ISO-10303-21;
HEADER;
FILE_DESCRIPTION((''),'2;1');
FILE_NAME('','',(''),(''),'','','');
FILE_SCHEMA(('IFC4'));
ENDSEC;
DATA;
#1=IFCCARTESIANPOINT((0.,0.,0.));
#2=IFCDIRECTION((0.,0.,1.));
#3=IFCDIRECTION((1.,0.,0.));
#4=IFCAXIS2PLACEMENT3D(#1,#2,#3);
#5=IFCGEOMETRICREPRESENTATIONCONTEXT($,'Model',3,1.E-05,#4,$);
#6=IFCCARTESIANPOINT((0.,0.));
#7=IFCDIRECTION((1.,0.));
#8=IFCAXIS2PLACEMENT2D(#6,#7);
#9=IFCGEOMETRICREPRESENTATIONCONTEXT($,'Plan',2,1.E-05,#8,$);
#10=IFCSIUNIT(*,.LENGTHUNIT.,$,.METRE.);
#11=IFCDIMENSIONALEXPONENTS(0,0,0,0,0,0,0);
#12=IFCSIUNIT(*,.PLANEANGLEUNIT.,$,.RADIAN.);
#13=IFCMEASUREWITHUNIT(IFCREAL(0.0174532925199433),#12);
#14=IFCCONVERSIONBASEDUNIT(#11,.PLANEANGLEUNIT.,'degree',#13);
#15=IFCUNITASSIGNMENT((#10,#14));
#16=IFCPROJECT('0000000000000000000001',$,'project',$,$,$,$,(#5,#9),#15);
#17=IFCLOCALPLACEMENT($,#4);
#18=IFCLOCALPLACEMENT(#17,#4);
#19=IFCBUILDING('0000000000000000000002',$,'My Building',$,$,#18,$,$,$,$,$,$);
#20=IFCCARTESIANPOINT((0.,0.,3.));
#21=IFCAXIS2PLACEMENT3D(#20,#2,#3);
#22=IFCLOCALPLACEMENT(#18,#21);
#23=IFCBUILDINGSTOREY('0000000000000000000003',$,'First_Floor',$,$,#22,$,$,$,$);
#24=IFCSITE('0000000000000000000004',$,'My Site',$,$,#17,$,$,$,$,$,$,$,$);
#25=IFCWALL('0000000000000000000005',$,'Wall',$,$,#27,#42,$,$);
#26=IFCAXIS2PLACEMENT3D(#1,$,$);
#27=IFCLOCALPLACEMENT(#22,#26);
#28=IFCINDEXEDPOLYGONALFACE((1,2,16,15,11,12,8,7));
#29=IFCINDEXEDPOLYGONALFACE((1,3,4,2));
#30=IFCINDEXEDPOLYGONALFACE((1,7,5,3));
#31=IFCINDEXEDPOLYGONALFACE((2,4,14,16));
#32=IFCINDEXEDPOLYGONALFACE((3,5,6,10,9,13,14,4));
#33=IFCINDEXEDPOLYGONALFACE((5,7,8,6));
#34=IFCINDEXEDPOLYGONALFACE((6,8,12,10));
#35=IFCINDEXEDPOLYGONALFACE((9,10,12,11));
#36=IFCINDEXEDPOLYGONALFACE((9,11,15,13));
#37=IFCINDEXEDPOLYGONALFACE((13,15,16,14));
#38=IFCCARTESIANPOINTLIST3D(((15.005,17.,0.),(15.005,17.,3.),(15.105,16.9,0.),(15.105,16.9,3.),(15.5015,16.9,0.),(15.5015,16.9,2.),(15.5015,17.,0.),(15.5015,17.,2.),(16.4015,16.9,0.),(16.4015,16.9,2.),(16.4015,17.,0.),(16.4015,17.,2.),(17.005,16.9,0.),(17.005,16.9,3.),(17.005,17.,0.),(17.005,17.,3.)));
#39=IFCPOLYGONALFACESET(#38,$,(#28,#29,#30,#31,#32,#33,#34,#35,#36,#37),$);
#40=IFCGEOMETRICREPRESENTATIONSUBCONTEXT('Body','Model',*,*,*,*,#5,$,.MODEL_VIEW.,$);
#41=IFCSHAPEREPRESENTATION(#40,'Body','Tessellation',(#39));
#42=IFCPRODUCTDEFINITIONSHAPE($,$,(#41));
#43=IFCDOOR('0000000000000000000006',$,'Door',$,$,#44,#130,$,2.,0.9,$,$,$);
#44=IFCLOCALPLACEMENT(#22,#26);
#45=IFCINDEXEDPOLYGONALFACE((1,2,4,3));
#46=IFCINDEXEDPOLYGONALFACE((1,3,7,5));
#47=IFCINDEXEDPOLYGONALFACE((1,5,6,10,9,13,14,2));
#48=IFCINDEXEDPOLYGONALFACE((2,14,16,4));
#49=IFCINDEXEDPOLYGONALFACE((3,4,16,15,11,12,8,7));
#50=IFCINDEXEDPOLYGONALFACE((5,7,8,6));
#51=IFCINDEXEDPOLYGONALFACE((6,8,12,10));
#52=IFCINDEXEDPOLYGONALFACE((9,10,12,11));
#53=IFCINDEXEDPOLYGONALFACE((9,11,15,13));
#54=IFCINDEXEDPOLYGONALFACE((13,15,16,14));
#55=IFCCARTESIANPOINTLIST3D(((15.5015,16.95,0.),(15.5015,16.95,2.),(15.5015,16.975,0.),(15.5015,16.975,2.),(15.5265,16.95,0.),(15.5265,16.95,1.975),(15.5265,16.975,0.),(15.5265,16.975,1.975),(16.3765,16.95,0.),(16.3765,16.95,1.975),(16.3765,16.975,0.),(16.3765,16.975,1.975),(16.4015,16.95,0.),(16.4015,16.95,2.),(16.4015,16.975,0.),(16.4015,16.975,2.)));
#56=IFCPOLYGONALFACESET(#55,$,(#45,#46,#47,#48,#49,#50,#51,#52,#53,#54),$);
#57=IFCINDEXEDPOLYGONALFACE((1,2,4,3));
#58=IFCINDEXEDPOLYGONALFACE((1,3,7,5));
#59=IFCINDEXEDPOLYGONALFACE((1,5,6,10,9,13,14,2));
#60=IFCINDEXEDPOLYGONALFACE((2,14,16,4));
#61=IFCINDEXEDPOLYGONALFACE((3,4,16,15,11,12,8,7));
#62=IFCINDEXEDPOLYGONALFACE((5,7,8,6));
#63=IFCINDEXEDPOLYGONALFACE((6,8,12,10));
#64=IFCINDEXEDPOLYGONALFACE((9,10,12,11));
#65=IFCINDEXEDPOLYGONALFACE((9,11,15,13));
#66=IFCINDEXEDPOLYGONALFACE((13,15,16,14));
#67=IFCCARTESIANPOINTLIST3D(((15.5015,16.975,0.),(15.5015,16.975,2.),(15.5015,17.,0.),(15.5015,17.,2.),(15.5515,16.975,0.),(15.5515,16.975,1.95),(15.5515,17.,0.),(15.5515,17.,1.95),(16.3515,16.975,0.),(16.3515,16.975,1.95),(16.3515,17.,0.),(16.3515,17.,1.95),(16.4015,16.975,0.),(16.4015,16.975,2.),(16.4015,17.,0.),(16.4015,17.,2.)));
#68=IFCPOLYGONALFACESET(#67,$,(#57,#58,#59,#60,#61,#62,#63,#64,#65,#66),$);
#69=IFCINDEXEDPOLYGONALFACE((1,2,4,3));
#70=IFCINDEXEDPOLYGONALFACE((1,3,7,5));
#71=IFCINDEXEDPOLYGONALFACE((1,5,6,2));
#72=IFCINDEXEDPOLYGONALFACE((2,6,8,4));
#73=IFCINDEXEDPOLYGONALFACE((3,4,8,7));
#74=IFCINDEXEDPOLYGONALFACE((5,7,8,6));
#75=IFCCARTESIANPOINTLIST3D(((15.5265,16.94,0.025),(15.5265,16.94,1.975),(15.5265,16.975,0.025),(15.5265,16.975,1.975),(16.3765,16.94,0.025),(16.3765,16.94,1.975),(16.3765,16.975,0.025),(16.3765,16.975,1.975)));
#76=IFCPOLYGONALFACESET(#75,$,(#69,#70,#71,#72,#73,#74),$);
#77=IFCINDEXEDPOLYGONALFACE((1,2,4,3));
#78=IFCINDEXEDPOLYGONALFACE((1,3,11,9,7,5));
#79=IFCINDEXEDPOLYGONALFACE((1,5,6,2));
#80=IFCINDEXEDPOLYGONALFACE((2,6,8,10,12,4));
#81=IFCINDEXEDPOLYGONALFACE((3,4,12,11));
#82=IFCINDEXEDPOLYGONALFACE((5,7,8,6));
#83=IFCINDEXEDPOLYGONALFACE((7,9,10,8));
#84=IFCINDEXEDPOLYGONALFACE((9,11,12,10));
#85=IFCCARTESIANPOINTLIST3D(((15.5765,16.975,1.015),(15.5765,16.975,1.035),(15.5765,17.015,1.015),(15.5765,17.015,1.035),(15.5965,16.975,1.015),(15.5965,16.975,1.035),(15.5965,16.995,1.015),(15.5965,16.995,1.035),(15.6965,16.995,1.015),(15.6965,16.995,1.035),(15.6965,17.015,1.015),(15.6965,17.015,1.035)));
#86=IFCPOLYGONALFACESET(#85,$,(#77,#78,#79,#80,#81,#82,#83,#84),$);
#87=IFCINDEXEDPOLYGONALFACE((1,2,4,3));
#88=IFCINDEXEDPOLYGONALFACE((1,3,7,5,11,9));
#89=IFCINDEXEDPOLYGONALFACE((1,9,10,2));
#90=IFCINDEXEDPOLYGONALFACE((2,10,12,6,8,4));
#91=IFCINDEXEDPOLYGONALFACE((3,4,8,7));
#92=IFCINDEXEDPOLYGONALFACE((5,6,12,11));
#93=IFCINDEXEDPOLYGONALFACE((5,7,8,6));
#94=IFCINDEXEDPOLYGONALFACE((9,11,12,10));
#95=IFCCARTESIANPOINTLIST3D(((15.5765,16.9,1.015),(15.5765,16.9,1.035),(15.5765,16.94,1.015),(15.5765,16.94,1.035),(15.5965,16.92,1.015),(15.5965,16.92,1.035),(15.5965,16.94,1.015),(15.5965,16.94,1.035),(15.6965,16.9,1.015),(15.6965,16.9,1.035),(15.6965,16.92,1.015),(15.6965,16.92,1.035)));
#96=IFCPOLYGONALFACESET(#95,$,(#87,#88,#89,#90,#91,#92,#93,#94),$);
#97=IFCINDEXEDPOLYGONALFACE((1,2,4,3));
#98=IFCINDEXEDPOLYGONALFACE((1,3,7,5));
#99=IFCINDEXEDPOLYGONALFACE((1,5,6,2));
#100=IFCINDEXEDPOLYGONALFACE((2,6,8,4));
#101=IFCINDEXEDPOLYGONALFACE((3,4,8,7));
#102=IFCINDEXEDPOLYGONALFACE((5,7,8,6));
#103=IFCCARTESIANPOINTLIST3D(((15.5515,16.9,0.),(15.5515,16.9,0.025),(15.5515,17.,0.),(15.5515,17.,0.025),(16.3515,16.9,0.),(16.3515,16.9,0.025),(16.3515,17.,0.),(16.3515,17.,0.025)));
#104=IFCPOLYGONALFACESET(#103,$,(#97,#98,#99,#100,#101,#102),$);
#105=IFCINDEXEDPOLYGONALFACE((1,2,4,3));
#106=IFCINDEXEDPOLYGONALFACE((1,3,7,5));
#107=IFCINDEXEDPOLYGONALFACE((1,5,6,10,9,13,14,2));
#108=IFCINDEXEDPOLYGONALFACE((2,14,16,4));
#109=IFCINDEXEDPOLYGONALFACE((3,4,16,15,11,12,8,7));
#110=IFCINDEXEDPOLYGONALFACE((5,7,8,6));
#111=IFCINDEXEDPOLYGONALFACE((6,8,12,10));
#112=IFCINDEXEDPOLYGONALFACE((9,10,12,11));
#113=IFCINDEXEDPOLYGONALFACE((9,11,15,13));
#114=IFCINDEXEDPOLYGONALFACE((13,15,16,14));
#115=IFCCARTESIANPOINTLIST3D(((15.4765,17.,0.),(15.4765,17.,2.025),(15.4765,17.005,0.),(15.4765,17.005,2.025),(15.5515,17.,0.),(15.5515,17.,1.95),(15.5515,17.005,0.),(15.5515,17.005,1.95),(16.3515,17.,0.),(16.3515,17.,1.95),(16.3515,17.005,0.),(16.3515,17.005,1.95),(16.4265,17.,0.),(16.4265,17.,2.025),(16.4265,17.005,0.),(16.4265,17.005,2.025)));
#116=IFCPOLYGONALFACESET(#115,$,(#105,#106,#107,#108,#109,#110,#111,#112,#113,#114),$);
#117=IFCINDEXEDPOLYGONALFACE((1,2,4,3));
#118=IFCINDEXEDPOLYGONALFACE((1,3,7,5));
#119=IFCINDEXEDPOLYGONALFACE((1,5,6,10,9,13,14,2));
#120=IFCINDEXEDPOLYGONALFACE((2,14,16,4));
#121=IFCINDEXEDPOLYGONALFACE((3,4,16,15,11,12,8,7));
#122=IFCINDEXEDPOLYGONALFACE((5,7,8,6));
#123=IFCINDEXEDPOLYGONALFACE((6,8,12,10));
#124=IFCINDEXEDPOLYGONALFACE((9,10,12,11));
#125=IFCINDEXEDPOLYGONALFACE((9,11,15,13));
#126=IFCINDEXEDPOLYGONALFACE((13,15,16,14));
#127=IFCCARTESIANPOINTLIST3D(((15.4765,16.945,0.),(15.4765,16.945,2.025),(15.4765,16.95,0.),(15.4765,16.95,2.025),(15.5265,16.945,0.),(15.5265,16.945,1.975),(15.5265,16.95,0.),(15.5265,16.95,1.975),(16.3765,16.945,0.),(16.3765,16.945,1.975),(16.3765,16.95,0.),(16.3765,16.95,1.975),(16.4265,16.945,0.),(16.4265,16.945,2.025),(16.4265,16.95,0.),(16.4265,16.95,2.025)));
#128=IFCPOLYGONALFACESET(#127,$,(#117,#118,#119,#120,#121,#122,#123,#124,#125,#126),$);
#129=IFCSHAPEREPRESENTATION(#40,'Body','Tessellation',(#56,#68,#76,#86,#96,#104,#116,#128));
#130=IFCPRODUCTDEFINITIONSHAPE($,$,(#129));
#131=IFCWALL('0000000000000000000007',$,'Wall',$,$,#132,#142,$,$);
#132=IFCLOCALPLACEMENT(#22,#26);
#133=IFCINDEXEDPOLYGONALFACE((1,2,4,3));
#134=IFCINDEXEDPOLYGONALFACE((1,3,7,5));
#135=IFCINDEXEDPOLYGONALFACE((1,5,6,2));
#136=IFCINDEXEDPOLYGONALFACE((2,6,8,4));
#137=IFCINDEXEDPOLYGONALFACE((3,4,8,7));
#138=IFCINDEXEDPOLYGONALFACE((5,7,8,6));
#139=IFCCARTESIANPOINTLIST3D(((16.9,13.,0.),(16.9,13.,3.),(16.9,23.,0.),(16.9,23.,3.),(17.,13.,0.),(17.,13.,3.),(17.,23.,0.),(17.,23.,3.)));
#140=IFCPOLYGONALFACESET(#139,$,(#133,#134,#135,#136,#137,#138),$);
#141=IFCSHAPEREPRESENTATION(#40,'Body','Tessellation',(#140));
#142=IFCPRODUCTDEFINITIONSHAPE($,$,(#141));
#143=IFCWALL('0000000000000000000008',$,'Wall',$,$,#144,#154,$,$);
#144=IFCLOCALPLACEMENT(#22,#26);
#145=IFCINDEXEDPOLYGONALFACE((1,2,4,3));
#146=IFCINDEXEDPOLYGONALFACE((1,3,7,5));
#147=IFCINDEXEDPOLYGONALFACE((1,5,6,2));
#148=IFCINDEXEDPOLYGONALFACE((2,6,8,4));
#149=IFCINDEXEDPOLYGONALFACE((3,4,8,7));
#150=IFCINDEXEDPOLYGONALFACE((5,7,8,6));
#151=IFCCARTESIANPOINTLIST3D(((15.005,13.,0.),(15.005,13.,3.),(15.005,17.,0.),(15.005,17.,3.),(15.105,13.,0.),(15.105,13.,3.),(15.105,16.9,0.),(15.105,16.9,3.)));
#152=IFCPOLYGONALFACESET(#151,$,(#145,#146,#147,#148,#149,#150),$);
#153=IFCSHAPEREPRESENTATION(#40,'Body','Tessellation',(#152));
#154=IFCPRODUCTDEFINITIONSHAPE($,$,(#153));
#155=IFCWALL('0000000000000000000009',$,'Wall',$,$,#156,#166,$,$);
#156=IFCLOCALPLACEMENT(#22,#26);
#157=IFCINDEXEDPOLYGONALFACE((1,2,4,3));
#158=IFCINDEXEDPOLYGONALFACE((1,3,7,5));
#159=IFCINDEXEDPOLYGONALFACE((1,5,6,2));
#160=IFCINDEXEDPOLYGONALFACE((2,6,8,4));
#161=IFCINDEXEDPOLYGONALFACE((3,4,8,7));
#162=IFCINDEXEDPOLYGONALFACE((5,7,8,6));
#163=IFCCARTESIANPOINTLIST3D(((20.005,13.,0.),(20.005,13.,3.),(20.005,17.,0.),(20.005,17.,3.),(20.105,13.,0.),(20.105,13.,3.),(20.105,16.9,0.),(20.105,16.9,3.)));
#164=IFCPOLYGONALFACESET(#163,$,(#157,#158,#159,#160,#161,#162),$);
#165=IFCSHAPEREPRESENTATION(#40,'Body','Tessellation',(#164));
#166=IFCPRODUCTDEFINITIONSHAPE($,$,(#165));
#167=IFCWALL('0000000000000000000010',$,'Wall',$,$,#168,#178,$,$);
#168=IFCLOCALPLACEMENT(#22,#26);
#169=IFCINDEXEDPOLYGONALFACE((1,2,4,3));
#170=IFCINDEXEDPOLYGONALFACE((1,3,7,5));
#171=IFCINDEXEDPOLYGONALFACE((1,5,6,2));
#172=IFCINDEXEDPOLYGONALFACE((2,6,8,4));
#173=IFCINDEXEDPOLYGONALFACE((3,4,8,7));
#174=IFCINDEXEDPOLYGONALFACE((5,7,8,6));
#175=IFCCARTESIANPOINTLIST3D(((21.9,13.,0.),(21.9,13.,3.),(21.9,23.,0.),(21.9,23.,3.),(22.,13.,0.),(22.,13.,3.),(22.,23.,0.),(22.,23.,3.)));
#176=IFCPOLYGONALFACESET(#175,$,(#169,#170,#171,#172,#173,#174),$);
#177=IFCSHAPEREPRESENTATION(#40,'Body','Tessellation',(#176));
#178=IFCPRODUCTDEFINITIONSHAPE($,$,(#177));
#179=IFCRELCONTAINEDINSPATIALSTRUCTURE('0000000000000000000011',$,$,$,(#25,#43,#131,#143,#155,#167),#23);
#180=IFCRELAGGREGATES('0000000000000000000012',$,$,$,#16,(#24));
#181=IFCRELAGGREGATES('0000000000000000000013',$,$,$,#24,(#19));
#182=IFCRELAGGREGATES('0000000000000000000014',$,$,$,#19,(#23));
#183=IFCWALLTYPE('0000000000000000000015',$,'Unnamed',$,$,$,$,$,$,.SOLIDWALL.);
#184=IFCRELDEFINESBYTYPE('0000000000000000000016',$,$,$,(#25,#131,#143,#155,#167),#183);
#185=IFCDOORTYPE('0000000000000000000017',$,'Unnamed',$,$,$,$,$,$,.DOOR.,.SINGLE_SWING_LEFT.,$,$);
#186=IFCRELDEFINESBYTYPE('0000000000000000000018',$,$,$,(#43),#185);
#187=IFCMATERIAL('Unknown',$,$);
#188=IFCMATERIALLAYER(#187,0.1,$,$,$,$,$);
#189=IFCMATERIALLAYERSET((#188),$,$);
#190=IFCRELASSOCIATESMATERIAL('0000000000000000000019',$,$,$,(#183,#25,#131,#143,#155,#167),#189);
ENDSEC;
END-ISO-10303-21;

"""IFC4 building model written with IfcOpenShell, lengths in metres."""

from ifc_helpers import new_model, entity, si_unit, converted_unit, frame, origin_with_axes, origin_2d_with_axis, place, context, subcontext, project, spatial, line, indexed_curve, outline, extrude, shape, source, transform, mapped, material, layer, layer_set, layer_usage, type_object, type_shapes, element, fill, save


model = new_model("IFC4")

# Units and contexts
model_context = context("Model", 3, precision=1e-05, world=origin_with_axes())
plan_context = context("Plan", 2, precision=1e-05, world=origin_2d_with_axis())
body_context_1 = subcontext(model_context, "Body", "Model", "MODEL_VIEW")
body_context_2 = subcontext(plan_context, "Body", "Plan", "PLAN_VIEW")
ifc_project = project(units=[si_unit("LENGTHUNIT", "METRE"), converted_unit("PLANEANGLEUNIT", "degree", entity("IfcReal", 0.0174532925199433), si_unit("PLANEANGLEUNIT", "RADIAN"), dimensions=[0, 0, 0, 0, 0, 0, 0])], contexts=[model_context, plan_context])

# Site, building, storey
site_placement = place(None, origin_with_axes())
site = spatial("IfcSite", under=ifc_project, at=site_placement, Name="My Site")
building_placement = place(site_placement, origin_with_axes())
building = spatial("IfcBuilding", under=site, at=building_placement, Name="My Building")
storey_placement = place(building_placement, frame((0.0, 0.0, 3.0), z_axis=(0.0, 0.0, 1.0), x_axis=(1.0, 0.0, 0.0)))
storey = spatial("IfcBuildingStorey", under=building, at=storey_placement, Name="First_Floor")

# Shared definitions
ifc_material = material(Name="Unknown")
ifc_layer = layer(ifc_material, 0.1)
ifc_layer_set = layer_set([ifc_layer])
wall_type = type_object("IfcWallType", Name="Unnamed", PredefinedType="SOLIDWALL", material=ifc_layer_set)
shared_shape_1 = source(origin_with_axes(), body_context_1, "Body", "SweptSolid", [
    extrude(outline(indexed_curve([(0.0, 0.0), (0.9, 0.0), (0.9, 2.0), (0.0, 2.0)], segments=[line(1, 2, 3, 4, 1)])), frame((0.0, -0.6, 0.0), z_axis=(0.0, -1.0, 0.0), x_axis=(1.0, 0.0, 0.0)), (0.0, 0.0, -1.0), 1.2),
])
door_type = type_object("IfcDoorType", Name="Unnamed", OperationType="SINGLE_SWING_LEFT", PredefinedType="DOOR")
shared_shape_2 = source(origin_with_axes(), body_context_1, "Body", "SweptSolid", [
    extrude(outline(indexed_curve([(0.0, 0.0), (0.0, 2.0), (0.9, 2.0), (0.9, 0.0), (0.875, 0.0), (0.875, 1.975), (0.025, 1.975), (0.025, 0.0)], segments=[line(1, 2, 3, 4, 5, 6, 7, 8, 1)])), frame((0.0, 0.025, 0.0), z_axis=(0.0, -1.0, 0.0), x_axis=(1.0, 0.0, 0.0)), (0.0, 0.0, -1.0), 0.025),
    extrude(outline(indexed_curve([(0.0, 0.0), (0.0, 2.0), (0.9, 2.0), (0.9, 0.0), (0.85, 0.0), (0.85, 1.95), (0.05, 1.95), (0.05, 0.0)], segments=[line(1, 2, 3, 4, 5, 6, 7, 8, 1)])), frame((0.0, 0.0, 0.0), z_axis=(0.0, -1.0, 0.0), x_axis=(1.0, 0.0, 0.0)), (0.0, 0.0, -1.0), 0.025),
    extrude(outline(indexed_curve([(0.0, 0.0), (0.85, 0.0), (0.85, 0.035), (0.0, 0.035)], segments=[line(1, 2, 3, 4, 1)])), frame((0.025, 0.025, 0.025), z_axis=(0.0, 0.0, 1.0), x_axis=(1.0, 0.0, 0.0)), (0.0, 0.0, 1.0), 1.95),
    extrude(outline(indexed_curve([(0.0, 0.0), (0.0, -0.04), (-0.12, -0.04), (-0.12, -0.02), (-0.02, -0.02), (-0.02, 0.0)], segments=[line(1, 2, 3, 4, 5, 6, 1)])), frame((0.825, 0.025, 1.015), z_axis=(0.0, 0.0, 1.0), x_axis=(1.0, 0.0, 0.0)), (0.0, 0.0, 1.0), 0.02),
    extrude(outline(indexed_curve([(0.0, 0.0), (0.0, 0.04), (-0.12, 0.04), (-0.12, 0.02), (-0.02, 0.02), (-0.02, 0.0)], segments=[line(1, 2, 3, 4, 5, 6, 1)])), frame((0.825, 0.06, 1.015), z_axis=(0.0, 0.0, 1.0), x_axis=(1.0, 0.0, 0.0)), (0.0, 0.0, 1.0), 0.02),
    extrude(outline(indexed_curve([(0.0, 0.0), (0.8, 0.0), (0.8, 0.1), (0.0, 0.1)], segments=[line(1, 2, 3, 4, 1)])), frame((0.05, 0.0, 0.0), z_axis=(0.0, 0.0, 1.0), x_axis=(1.0, 0.0, 0.0)), (0.0, 0.0, 1.0), 0.025),
    extrude(outline(indexed_curve([(0.0, 0.0), (0.0, 2.025), (0.95, 2.025), (0.95, 0.0), (0.875, 0.0), (0.875, 1.95), (0.075, 1.95), (0.075, 0.0)], segments=[line(1, 2, 3, 4, 5, 6, 7, 8, 1)])), frame((-0.025, -0.005, 0.0), z_axis=(0.0, -1.0, 0.0), x_axis=(1.0, 0.0, 0.0)), (0.0, 0.0, -1.0), 0.005),
    extrude(outline(indexed_curve([(0.0, 0.0), (0.0, 2.025), (0.95, 2.025), (0.95, 0.0), (0.9, 0.0), (0.9, 1.975), (0.05, 1.975), (0.05, 0.0)], segments=[line(1, 2, 3, 4, 5, 6, 7, 8, 1)])), frame((-0.025, 0.05, 0.0), z_axis=(0.0, -1.0, 0.0), x_axis=(1.0, 0.0, 0.0)), (0.0, 0.0, -1.0), 0.005),
])
shared_shape_3 = source(origin_with_axes(), body_context_2, "Body", "Curve2D", [
    entity("IfcIndexedPolyCurve", entity("IfcCartesianPointList2D", [[0.0, 0.0], [0.0, 0.05], [0.025, 0.05], [0.025, 0.025], [0.05, 0.025], [0.05, 0.0]]), [entity("IfcLineIndex", [1, 2, 3, 4, 5, 6, 1])]),
    entity("IfcIndexedPolyCurve", entity("IfcCartesianPointList2D", [[0.9, 0.0], [0.9, 0.05], [0.875, 0.05], [0.875, 0.025], [0.85, 0.025], [0.85, 0.0]]), [entity("IfcLineIndex", [1, 2, 3, 4, 5, 6, 1])]),
    entity("IfcTrimmedCurve", entity("IfcEllipse", entity("IfcAxis2Placement2D", entity("IfcCartesianPoint", [0.06, 0.05]), entity("IfcDirection", [1.0, 0.0])), 0.815, 0.85), [entity("IfcCartesianPoint", [0.875, 0.05])], [entity("IfcCartesianPoint", [0.06, 0.9])], True, "CARTESIAN"),
    entity("IfcIndexedPolyCurve", entity("IfcCartesianPointList2D", [[0.025, 0.05], [0.06, 0.05], [0.06, 0.9], [0.025, 0.9]]), [entity("IfcLineIndex", [1, 2, 3, 4, 1])]),
])
type_shapes(door_type, [shared_shape_2, shared_shape_3])

# Wall, opening, door
ifc_layer_usage_1 = layer_usage(ifc_layer_set, "AXIS2", "POSITIVE", 0.0)
wall_1_placement = place(storey_placement, frame((17.005, 17.0, 0.0), z_axis=(0.0, 0.0, 1.0), x_axis=(-1.0, 0.0, 0.0)))
wall_1 = element("IfcWall", 1, at=wall_1_placement, inside=storey, type_object=wall_type, material=ifc_layer_usage_1, Name="Wall", context=body_context_1, shape_type="SweptSolid", body=[
    extrude(outline(indexed_curve([(0.0, 0.0), (0.0, 0.1), (1.9, 0.1), (2.0, 0.0)], segments=[line(1, 2, 3, 4, 1)])), origin_with_axes(), (0.0, 0.0, 1.0), 3.0),
])
opening_1_placement = place(wall_1_placement, frame((0.6035, 0.0, 0.0), z_axis=(0.0, 0.0, 1.0), x_axis=(1.0, 0.0, 0.0)))
opening_1 = element("IfcOpeningElement", 2, at=opening_1_placement, cuts=wall_1, PredefinedType="OPENING", context=body_context_1, shape_type="MappedRepresentation", body=[
    mapped(shared_shape_1, transform((0.0, 0.0, 0.0), x_axis=(1.0, 0.0, 0.0), y_axis=(0.0, 1.0, 0.0), z_axis=(0.0, 0.0, 1.0), scale=1.0)),
])
door_1_placement = place(opening_1_placement, frame((0.0, 0.0, 0.0), z_axis=(0.0, 0.0, 1.0), x_axis=(1.0, 0.0, 0.0)))
door_1 = element("IfcDoor", 3, at=door_1_placement, inside=storey, type_object=door_type, Name="Door", OverallHeight=2.0, OverallWidth=0.9, shapes=[
    shape(body_context_1, "Body", "MappedRepresentation", [mapped(shared_shape_2, transform((0.0, 0.0, 0.0), x_axis=(1.0, 0.0, 0.0), y_axis=(0.0, 1.0, 0.0), z_axis=(0.0, 0.0, 1.0), scale=1.0))]),
    shape(body_context_2, "Body", "MappedRepresentation", [mapped(shared_shape_3, transform((0.0, 0.0, 0.0), x_axis=(1.0, 0.0, 0.0), y_axis=(0.0, 1.0, 0.0), z_axis=(0.0, 0.0, 1.0), scale=1.0))]),
])
fill(opening_1, door_1)

# Walls
ifc_layer_usage_2 = layer_usage(ifc_layer_set, "AXIS2", "POSITIVE", 0.0)
wall_2_placement = place(storey_placement, frame((16.9, 23.0, 0.0), z_axis=(0.0, 0.0, 1.0), x_axis=(0.0, -1.0, 0.0)))
element("IfcWall", 4, at=wall_2_placement, inside=storey, type_object=wall_type, material=ifc_layer_usage_2, Name="Wall", context=body_context_1, shape_type="SweptSolid", body=[
    extrude(outline(indexed_curve([(0.0, 0.0), (0.0, 0.1), (10.0, 0.1), (10.0, 0.0)], segments=[line(1, 2, 3, 4, 1)])), origin_with_axes(), (0.0, 0.0, 1.0), 3.0),
])
ifc_layer_usage_3 = layer_usage(ifc_layer_set, "AXIS2", "POSITIVE", 0.0)
wall_3_placement = place(storey_placement, frame((15.005, 17.0, 0.0), z_axis=(0.0, 0.0, 1.0), x_axis=(0.0, -1.0, 0.0)))
element("IfcWall", 5, at=wall_3_placement, inside=storey, type_object=wall_type, material=ifc_layer_usage_3, Name="Wall", context=body_context_1, shape_type="SweptSolid", body=[
    extrude(outline(indexed_curve([(0.0, 0.0), (0.1, 0.1), (4.0, 0.1), (4.0, 0.0)], segments=[line(1, 2, 3, 4, 1)])), origin_with_axes(), (0.0, 0.0, 1.0), 3.0),
])
ifc_layer_usage_4 = layer_usage(ifc_layer_set, "AXIS2", "POSITIVE", 0.0)
wall_4_placement = place(storey_placement, frame((20.005, 17.0, 0.0), z_axis=(0.0, 0.0, 1.0), x_axis=(0.0, -1.0, 0.0)))
element("IfcWall", 6, at=wall_4_placement, inside=storey, type_object=wall_type, material=ifc_layer_usage_4, Name="Wall", context=body_context_1, shape_type="SweptSolid", body=[
    extrude(outline(indexed_curve([(0.0, 0.0), (0.1, 0.1), (4.0, 0.1), (4.0, 0.0)], segments=[line(1, 2, 3, 4, 1)])), origin_with_axes(), (0.0, 0.0, 1.0), 3.0),
])
ifc_layer_usage_5 = layer_usage(ifc_layer_set, "AXIS2", "POSITIVE", 0.0)
wall_5_placement = place(storey_placement, frame((21.9, 23.0, 0.0), z_axis=(0.0, 0.0, 1.0), x_axis=(0.0, -1.0, 0.0)))
element("IfcWall", 7, at=wall_5_placement, inside=storey, type_object=wall_type, material=ifc_layer_usage_5, Name="Wall", context=body_context_1, shape_type="SweptSolid", body=[
    extrude(outline(indexed_curve([(0.0, 0.0), (0.0, 0.1), (10.0, 0.1), (10.0, 0.0)], segments=[line(1, 2, 3, 4, 1)])), origin_with_axes(), (0.0, 0.0, 1.0), 3.0),
])

save(model, "model.ifc")
